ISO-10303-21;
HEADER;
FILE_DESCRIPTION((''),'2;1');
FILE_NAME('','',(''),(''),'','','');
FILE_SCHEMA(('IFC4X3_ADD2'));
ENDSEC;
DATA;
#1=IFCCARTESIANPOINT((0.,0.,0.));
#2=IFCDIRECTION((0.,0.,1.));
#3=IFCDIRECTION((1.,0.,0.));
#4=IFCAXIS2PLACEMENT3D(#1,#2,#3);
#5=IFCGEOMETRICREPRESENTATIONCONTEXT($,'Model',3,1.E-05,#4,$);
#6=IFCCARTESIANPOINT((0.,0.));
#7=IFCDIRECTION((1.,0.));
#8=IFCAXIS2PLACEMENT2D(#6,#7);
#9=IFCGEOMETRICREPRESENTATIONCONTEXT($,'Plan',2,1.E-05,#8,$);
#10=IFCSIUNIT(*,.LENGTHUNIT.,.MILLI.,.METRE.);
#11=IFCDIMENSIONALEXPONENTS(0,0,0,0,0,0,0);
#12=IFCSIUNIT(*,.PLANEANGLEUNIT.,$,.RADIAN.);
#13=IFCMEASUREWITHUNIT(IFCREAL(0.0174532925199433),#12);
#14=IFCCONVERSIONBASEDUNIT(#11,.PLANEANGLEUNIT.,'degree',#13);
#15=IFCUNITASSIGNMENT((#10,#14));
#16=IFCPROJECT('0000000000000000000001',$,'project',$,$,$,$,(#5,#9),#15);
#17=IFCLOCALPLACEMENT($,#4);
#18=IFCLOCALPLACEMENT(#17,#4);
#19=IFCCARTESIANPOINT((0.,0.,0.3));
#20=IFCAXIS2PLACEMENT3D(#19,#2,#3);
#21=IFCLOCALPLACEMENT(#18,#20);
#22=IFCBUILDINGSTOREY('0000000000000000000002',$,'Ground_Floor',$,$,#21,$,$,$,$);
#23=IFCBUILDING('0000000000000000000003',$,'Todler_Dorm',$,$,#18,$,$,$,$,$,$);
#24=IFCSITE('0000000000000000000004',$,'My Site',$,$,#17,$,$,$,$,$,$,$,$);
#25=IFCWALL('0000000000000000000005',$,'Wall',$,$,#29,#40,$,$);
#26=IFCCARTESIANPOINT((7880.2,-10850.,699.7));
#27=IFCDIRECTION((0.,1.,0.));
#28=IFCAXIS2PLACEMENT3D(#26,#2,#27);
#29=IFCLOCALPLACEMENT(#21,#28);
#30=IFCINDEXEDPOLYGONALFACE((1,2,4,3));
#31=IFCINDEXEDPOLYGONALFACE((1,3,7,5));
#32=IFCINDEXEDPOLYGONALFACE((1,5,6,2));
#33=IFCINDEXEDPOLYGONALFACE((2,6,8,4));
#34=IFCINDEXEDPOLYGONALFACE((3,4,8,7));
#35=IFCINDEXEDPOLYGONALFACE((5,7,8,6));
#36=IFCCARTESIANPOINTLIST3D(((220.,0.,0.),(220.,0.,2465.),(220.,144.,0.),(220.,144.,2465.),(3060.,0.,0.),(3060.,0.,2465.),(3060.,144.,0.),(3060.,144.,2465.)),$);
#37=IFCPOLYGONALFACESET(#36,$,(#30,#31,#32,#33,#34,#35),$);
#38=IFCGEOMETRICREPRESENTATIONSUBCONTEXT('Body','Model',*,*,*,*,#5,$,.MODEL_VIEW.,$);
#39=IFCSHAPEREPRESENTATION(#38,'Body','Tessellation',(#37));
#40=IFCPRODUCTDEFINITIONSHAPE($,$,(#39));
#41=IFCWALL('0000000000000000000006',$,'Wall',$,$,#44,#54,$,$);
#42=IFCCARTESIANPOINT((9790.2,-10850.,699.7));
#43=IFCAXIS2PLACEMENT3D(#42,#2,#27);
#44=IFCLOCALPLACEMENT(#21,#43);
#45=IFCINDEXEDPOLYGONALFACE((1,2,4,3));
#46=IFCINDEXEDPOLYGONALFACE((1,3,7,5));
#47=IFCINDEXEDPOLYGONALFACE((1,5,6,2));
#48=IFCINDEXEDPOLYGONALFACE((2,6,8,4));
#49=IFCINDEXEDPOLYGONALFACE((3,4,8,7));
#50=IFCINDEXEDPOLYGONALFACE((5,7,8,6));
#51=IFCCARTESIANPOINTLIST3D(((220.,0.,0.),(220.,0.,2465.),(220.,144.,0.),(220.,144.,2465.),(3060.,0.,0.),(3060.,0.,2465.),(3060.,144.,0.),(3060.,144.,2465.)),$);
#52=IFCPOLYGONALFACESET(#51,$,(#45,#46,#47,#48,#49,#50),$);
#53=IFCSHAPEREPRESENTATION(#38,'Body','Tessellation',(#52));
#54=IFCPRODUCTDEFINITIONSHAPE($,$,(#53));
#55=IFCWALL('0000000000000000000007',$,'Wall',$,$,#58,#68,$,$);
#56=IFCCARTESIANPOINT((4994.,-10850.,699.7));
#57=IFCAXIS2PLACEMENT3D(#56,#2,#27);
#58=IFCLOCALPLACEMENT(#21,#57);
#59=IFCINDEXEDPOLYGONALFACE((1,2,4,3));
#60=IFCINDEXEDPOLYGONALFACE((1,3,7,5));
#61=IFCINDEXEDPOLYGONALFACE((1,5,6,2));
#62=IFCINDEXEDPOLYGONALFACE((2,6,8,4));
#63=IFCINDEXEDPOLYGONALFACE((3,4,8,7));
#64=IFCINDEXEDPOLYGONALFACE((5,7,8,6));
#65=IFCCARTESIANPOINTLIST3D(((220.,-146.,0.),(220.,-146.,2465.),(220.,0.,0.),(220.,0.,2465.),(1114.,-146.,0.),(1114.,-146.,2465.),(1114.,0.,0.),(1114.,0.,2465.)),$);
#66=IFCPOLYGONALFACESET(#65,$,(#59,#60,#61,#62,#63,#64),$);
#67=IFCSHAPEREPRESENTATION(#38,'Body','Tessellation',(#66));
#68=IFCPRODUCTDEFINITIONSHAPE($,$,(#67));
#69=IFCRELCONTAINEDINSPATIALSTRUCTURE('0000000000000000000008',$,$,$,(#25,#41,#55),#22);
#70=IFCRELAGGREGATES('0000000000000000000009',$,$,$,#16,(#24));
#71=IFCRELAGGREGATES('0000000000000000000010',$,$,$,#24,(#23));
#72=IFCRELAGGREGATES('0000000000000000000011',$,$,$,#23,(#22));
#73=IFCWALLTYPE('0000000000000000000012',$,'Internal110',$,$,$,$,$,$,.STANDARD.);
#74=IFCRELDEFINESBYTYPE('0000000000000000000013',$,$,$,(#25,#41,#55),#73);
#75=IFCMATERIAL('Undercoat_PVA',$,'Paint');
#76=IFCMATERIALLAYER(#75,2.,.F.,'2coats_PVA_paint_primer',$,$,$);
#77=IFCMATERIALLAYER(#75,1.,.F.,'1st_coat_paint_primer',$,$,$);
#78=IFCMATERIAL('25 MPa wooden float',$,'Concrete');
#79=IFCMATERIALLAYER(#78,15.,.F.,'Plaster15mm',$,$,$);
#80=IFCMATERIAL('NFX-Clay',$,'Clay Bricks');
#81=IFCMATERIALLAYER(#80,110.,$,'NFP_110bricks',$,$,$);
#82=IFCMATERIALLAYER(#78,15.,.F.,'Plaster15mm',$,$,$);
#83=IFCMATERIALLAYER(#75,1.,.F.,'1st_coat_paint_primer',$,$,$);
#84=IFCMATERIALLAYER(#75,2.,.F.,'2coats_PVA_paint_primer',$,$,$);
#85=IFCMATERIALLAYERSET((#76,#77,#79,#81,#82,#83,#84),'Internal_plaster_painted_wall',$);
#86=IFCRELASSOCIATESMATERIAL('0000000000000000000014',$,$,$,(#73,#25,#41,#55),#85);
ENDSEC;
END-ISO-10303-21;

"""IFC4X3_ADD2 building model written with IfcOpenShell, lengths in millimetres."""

from ifc_helpers import new_model, entity, si_unit, converted_unit, frame, origin_with_axes, origin_2d_with_axis, place, context, subcontext, project, spatial, line, indexed_curve, outline, extrude, material, layer, layer_set, layer_usage, type_object, element, save


model = new_model("IFC4X3_ADD2")

# Units and contexts
model_context = context("Model", 3, precision=1e-05, world=origin_with_axes())
plan_context = context("Plan", 2, precision=1e-05, world=origin_2d_with_axis())
body_context_1 = subcontext(model_context, "Body", "Model", "MODEL_VIEW")
ifc_project = project(units=[si_unit("LENGTHUNIT", "METRE", prefix="MILLI"), converted_unit("PLANEANGLEUNIT", "degree", entity("IfcReal", 0.0174532925199433), si_unit("PLANEANGLEUNIT", "RADIAN"), dimensions=[0, 0, 0, 0, 0, 0, 0])], contexts=[model_context, plan_context])

# Site, building, storey
site_placement = place(None, origin_with_axes())
site = spatial("IfcSite", under=ifc_project, at=site_placement, Name="My Site")
building_placement = place(site_placement, origin_with_axes())
building = spatial("IfcBuilding", under=site, at=building_placement, Name="Todler_Dorm")
storey_placement = place(building_placement, frame((0.0, 0.0, 0.3), z_axis=(0.0, 0.0, 1.0), x_axis=(1.0, 0.0, 0.0)))
storey = spatial("IfcBuildingStorey", under=building, at=storey_placement, Name="Ground_Floor")

# Shared definitions
ifc_material_1 = material(Name="Undercoat_PVA", Category="Paint")
ifc_layer_1 = layer(ifc_material_1, 2.0, ventilated=False, Name="2coats_PVA_paint_primer")
ifc_layer_2 = layer(ifc_material_1, 1.0, ventilated=False, Name="1st_coat_paint_primer")
ifc_material_2 = material(Name="25 MPa wooden float", Category="Concrete")
ifc_layer_3 = layer(ifc_material_2, 15.0, ventilated=False, Name="Plaster15mm")
ifc_material_3 = material(Name="NFX-Clay", Category="Clay Bricks")
ifc_layer_4 = layer(ifc_material_3, 110.0, Name="NFP_110bricks")
ifc_layer_5 = layer(ifc_material_2, 15.0, ventilated=False, Name="Plaster15mm")
ifc_layer_6 = layer(ifc_material_1, 1.0, ventilated=False, Name="1st_coat_paint_primer")
ifc_layer_7 = layer(ifc_material_1, 2.0, ventilated=False, Name="2coats_PVA_paint_primer")
ifc_layer_set_1 = layer_set([ifc_layer_1, ifc_layer_2, ifc_layer_3, ifc_layer_4, ifc_layer_5, ifc_layer_6, ifc_layer_7], Name="Internal_plaster_painted_wall")
wall_type_1 = type_object("IfcWallType", Name="Internal110", PredefinedType="STANDARD", material=ifc_layer_set_1)

# Walls
ifc_layer_usage_1 = layer_usage(ifc_layer_set_1, "AXIS2", "POSITIVE", 0.0)
wall_1_placement = place(storey_placement, frame((7880.2, -10850.0, 699.7), z_axis=(0.0, 0.0, 1.0), x_axis=(0.0, 1.0, 0.0)))
element("IfcWall", 1, at=wall_1_placement, inside=storey, type_object=wall_type_1, material=ifc_layer_usage_1, Name="Wall", context=body_context_1, shape_type="SweptSolid", body=[
    extrude(outline(indexed_curve([(220.0, 0.0), (220.0, 144.0), (3060.0, 144.0), (3060.0, 0.0)], segments=[line(1, 2, 3, 4, 1)])), origin_with_axes(), (0.0, 0.0, 1.0), 2465.0),
])
ifc_layer_usage_2 = layer_usage(ifc_layer_set_1, "AXIS2", "POSITIVE", 0.0)
wall_2_placement = place(storey_placement, frame((9790.2, -10850.0, 699.7), z_axis=(0.0, 0.0, 1.0), x_axis=(0.0, 1.0, 0.0)))
element("IfcWall", 2, at=wall_2_placement, inside=storey, type_object=wall_type_1, material=ifc_layer_usage_2, Name="Wall", context=body_context_1, shape_type="SweptSolid", body=[
    extrude(outline(indexed_curve([(220.0, 0.0), (220.0, 144.0), (3060.0, 144.0), (3060.0, 0.0)], segments=[line(1, 2, 3, 4, 1)])), origin_with_axes(), (0.0, 0.0, 1.0), 2465.0),
])
ifc_layer_usage_3 = layer_usage(ifc_layer_set_1, "AXIS2", "NEGATIVE", 0.0)
wall_3_placement = place(storey_placement, frame((4994.0, -10850.0, 699.7), z_axis=(0.0, 0.0, 1.0), x_axis=(0.0, 1.0, 0.0)))
element("IfcWall", 3, at=wall_3_placement, inside=storey, type_object=wall_type_1, material=ifc_layer_usage_3, Name="Wall", context=body_context_1, shape_type="SweptSolid", body=[
    extrude(outline(indexed_curve([(220.0, -146.0), (220.0, 0.0), (1114.0, 0.0), (1114.0, -146.0)], segments=[line(1, 2, 3, 4, 1)])), origin_with_axes(), (0.0, 0.0, 1.0), 2465.0),
])

save(model, "model.ifc")
